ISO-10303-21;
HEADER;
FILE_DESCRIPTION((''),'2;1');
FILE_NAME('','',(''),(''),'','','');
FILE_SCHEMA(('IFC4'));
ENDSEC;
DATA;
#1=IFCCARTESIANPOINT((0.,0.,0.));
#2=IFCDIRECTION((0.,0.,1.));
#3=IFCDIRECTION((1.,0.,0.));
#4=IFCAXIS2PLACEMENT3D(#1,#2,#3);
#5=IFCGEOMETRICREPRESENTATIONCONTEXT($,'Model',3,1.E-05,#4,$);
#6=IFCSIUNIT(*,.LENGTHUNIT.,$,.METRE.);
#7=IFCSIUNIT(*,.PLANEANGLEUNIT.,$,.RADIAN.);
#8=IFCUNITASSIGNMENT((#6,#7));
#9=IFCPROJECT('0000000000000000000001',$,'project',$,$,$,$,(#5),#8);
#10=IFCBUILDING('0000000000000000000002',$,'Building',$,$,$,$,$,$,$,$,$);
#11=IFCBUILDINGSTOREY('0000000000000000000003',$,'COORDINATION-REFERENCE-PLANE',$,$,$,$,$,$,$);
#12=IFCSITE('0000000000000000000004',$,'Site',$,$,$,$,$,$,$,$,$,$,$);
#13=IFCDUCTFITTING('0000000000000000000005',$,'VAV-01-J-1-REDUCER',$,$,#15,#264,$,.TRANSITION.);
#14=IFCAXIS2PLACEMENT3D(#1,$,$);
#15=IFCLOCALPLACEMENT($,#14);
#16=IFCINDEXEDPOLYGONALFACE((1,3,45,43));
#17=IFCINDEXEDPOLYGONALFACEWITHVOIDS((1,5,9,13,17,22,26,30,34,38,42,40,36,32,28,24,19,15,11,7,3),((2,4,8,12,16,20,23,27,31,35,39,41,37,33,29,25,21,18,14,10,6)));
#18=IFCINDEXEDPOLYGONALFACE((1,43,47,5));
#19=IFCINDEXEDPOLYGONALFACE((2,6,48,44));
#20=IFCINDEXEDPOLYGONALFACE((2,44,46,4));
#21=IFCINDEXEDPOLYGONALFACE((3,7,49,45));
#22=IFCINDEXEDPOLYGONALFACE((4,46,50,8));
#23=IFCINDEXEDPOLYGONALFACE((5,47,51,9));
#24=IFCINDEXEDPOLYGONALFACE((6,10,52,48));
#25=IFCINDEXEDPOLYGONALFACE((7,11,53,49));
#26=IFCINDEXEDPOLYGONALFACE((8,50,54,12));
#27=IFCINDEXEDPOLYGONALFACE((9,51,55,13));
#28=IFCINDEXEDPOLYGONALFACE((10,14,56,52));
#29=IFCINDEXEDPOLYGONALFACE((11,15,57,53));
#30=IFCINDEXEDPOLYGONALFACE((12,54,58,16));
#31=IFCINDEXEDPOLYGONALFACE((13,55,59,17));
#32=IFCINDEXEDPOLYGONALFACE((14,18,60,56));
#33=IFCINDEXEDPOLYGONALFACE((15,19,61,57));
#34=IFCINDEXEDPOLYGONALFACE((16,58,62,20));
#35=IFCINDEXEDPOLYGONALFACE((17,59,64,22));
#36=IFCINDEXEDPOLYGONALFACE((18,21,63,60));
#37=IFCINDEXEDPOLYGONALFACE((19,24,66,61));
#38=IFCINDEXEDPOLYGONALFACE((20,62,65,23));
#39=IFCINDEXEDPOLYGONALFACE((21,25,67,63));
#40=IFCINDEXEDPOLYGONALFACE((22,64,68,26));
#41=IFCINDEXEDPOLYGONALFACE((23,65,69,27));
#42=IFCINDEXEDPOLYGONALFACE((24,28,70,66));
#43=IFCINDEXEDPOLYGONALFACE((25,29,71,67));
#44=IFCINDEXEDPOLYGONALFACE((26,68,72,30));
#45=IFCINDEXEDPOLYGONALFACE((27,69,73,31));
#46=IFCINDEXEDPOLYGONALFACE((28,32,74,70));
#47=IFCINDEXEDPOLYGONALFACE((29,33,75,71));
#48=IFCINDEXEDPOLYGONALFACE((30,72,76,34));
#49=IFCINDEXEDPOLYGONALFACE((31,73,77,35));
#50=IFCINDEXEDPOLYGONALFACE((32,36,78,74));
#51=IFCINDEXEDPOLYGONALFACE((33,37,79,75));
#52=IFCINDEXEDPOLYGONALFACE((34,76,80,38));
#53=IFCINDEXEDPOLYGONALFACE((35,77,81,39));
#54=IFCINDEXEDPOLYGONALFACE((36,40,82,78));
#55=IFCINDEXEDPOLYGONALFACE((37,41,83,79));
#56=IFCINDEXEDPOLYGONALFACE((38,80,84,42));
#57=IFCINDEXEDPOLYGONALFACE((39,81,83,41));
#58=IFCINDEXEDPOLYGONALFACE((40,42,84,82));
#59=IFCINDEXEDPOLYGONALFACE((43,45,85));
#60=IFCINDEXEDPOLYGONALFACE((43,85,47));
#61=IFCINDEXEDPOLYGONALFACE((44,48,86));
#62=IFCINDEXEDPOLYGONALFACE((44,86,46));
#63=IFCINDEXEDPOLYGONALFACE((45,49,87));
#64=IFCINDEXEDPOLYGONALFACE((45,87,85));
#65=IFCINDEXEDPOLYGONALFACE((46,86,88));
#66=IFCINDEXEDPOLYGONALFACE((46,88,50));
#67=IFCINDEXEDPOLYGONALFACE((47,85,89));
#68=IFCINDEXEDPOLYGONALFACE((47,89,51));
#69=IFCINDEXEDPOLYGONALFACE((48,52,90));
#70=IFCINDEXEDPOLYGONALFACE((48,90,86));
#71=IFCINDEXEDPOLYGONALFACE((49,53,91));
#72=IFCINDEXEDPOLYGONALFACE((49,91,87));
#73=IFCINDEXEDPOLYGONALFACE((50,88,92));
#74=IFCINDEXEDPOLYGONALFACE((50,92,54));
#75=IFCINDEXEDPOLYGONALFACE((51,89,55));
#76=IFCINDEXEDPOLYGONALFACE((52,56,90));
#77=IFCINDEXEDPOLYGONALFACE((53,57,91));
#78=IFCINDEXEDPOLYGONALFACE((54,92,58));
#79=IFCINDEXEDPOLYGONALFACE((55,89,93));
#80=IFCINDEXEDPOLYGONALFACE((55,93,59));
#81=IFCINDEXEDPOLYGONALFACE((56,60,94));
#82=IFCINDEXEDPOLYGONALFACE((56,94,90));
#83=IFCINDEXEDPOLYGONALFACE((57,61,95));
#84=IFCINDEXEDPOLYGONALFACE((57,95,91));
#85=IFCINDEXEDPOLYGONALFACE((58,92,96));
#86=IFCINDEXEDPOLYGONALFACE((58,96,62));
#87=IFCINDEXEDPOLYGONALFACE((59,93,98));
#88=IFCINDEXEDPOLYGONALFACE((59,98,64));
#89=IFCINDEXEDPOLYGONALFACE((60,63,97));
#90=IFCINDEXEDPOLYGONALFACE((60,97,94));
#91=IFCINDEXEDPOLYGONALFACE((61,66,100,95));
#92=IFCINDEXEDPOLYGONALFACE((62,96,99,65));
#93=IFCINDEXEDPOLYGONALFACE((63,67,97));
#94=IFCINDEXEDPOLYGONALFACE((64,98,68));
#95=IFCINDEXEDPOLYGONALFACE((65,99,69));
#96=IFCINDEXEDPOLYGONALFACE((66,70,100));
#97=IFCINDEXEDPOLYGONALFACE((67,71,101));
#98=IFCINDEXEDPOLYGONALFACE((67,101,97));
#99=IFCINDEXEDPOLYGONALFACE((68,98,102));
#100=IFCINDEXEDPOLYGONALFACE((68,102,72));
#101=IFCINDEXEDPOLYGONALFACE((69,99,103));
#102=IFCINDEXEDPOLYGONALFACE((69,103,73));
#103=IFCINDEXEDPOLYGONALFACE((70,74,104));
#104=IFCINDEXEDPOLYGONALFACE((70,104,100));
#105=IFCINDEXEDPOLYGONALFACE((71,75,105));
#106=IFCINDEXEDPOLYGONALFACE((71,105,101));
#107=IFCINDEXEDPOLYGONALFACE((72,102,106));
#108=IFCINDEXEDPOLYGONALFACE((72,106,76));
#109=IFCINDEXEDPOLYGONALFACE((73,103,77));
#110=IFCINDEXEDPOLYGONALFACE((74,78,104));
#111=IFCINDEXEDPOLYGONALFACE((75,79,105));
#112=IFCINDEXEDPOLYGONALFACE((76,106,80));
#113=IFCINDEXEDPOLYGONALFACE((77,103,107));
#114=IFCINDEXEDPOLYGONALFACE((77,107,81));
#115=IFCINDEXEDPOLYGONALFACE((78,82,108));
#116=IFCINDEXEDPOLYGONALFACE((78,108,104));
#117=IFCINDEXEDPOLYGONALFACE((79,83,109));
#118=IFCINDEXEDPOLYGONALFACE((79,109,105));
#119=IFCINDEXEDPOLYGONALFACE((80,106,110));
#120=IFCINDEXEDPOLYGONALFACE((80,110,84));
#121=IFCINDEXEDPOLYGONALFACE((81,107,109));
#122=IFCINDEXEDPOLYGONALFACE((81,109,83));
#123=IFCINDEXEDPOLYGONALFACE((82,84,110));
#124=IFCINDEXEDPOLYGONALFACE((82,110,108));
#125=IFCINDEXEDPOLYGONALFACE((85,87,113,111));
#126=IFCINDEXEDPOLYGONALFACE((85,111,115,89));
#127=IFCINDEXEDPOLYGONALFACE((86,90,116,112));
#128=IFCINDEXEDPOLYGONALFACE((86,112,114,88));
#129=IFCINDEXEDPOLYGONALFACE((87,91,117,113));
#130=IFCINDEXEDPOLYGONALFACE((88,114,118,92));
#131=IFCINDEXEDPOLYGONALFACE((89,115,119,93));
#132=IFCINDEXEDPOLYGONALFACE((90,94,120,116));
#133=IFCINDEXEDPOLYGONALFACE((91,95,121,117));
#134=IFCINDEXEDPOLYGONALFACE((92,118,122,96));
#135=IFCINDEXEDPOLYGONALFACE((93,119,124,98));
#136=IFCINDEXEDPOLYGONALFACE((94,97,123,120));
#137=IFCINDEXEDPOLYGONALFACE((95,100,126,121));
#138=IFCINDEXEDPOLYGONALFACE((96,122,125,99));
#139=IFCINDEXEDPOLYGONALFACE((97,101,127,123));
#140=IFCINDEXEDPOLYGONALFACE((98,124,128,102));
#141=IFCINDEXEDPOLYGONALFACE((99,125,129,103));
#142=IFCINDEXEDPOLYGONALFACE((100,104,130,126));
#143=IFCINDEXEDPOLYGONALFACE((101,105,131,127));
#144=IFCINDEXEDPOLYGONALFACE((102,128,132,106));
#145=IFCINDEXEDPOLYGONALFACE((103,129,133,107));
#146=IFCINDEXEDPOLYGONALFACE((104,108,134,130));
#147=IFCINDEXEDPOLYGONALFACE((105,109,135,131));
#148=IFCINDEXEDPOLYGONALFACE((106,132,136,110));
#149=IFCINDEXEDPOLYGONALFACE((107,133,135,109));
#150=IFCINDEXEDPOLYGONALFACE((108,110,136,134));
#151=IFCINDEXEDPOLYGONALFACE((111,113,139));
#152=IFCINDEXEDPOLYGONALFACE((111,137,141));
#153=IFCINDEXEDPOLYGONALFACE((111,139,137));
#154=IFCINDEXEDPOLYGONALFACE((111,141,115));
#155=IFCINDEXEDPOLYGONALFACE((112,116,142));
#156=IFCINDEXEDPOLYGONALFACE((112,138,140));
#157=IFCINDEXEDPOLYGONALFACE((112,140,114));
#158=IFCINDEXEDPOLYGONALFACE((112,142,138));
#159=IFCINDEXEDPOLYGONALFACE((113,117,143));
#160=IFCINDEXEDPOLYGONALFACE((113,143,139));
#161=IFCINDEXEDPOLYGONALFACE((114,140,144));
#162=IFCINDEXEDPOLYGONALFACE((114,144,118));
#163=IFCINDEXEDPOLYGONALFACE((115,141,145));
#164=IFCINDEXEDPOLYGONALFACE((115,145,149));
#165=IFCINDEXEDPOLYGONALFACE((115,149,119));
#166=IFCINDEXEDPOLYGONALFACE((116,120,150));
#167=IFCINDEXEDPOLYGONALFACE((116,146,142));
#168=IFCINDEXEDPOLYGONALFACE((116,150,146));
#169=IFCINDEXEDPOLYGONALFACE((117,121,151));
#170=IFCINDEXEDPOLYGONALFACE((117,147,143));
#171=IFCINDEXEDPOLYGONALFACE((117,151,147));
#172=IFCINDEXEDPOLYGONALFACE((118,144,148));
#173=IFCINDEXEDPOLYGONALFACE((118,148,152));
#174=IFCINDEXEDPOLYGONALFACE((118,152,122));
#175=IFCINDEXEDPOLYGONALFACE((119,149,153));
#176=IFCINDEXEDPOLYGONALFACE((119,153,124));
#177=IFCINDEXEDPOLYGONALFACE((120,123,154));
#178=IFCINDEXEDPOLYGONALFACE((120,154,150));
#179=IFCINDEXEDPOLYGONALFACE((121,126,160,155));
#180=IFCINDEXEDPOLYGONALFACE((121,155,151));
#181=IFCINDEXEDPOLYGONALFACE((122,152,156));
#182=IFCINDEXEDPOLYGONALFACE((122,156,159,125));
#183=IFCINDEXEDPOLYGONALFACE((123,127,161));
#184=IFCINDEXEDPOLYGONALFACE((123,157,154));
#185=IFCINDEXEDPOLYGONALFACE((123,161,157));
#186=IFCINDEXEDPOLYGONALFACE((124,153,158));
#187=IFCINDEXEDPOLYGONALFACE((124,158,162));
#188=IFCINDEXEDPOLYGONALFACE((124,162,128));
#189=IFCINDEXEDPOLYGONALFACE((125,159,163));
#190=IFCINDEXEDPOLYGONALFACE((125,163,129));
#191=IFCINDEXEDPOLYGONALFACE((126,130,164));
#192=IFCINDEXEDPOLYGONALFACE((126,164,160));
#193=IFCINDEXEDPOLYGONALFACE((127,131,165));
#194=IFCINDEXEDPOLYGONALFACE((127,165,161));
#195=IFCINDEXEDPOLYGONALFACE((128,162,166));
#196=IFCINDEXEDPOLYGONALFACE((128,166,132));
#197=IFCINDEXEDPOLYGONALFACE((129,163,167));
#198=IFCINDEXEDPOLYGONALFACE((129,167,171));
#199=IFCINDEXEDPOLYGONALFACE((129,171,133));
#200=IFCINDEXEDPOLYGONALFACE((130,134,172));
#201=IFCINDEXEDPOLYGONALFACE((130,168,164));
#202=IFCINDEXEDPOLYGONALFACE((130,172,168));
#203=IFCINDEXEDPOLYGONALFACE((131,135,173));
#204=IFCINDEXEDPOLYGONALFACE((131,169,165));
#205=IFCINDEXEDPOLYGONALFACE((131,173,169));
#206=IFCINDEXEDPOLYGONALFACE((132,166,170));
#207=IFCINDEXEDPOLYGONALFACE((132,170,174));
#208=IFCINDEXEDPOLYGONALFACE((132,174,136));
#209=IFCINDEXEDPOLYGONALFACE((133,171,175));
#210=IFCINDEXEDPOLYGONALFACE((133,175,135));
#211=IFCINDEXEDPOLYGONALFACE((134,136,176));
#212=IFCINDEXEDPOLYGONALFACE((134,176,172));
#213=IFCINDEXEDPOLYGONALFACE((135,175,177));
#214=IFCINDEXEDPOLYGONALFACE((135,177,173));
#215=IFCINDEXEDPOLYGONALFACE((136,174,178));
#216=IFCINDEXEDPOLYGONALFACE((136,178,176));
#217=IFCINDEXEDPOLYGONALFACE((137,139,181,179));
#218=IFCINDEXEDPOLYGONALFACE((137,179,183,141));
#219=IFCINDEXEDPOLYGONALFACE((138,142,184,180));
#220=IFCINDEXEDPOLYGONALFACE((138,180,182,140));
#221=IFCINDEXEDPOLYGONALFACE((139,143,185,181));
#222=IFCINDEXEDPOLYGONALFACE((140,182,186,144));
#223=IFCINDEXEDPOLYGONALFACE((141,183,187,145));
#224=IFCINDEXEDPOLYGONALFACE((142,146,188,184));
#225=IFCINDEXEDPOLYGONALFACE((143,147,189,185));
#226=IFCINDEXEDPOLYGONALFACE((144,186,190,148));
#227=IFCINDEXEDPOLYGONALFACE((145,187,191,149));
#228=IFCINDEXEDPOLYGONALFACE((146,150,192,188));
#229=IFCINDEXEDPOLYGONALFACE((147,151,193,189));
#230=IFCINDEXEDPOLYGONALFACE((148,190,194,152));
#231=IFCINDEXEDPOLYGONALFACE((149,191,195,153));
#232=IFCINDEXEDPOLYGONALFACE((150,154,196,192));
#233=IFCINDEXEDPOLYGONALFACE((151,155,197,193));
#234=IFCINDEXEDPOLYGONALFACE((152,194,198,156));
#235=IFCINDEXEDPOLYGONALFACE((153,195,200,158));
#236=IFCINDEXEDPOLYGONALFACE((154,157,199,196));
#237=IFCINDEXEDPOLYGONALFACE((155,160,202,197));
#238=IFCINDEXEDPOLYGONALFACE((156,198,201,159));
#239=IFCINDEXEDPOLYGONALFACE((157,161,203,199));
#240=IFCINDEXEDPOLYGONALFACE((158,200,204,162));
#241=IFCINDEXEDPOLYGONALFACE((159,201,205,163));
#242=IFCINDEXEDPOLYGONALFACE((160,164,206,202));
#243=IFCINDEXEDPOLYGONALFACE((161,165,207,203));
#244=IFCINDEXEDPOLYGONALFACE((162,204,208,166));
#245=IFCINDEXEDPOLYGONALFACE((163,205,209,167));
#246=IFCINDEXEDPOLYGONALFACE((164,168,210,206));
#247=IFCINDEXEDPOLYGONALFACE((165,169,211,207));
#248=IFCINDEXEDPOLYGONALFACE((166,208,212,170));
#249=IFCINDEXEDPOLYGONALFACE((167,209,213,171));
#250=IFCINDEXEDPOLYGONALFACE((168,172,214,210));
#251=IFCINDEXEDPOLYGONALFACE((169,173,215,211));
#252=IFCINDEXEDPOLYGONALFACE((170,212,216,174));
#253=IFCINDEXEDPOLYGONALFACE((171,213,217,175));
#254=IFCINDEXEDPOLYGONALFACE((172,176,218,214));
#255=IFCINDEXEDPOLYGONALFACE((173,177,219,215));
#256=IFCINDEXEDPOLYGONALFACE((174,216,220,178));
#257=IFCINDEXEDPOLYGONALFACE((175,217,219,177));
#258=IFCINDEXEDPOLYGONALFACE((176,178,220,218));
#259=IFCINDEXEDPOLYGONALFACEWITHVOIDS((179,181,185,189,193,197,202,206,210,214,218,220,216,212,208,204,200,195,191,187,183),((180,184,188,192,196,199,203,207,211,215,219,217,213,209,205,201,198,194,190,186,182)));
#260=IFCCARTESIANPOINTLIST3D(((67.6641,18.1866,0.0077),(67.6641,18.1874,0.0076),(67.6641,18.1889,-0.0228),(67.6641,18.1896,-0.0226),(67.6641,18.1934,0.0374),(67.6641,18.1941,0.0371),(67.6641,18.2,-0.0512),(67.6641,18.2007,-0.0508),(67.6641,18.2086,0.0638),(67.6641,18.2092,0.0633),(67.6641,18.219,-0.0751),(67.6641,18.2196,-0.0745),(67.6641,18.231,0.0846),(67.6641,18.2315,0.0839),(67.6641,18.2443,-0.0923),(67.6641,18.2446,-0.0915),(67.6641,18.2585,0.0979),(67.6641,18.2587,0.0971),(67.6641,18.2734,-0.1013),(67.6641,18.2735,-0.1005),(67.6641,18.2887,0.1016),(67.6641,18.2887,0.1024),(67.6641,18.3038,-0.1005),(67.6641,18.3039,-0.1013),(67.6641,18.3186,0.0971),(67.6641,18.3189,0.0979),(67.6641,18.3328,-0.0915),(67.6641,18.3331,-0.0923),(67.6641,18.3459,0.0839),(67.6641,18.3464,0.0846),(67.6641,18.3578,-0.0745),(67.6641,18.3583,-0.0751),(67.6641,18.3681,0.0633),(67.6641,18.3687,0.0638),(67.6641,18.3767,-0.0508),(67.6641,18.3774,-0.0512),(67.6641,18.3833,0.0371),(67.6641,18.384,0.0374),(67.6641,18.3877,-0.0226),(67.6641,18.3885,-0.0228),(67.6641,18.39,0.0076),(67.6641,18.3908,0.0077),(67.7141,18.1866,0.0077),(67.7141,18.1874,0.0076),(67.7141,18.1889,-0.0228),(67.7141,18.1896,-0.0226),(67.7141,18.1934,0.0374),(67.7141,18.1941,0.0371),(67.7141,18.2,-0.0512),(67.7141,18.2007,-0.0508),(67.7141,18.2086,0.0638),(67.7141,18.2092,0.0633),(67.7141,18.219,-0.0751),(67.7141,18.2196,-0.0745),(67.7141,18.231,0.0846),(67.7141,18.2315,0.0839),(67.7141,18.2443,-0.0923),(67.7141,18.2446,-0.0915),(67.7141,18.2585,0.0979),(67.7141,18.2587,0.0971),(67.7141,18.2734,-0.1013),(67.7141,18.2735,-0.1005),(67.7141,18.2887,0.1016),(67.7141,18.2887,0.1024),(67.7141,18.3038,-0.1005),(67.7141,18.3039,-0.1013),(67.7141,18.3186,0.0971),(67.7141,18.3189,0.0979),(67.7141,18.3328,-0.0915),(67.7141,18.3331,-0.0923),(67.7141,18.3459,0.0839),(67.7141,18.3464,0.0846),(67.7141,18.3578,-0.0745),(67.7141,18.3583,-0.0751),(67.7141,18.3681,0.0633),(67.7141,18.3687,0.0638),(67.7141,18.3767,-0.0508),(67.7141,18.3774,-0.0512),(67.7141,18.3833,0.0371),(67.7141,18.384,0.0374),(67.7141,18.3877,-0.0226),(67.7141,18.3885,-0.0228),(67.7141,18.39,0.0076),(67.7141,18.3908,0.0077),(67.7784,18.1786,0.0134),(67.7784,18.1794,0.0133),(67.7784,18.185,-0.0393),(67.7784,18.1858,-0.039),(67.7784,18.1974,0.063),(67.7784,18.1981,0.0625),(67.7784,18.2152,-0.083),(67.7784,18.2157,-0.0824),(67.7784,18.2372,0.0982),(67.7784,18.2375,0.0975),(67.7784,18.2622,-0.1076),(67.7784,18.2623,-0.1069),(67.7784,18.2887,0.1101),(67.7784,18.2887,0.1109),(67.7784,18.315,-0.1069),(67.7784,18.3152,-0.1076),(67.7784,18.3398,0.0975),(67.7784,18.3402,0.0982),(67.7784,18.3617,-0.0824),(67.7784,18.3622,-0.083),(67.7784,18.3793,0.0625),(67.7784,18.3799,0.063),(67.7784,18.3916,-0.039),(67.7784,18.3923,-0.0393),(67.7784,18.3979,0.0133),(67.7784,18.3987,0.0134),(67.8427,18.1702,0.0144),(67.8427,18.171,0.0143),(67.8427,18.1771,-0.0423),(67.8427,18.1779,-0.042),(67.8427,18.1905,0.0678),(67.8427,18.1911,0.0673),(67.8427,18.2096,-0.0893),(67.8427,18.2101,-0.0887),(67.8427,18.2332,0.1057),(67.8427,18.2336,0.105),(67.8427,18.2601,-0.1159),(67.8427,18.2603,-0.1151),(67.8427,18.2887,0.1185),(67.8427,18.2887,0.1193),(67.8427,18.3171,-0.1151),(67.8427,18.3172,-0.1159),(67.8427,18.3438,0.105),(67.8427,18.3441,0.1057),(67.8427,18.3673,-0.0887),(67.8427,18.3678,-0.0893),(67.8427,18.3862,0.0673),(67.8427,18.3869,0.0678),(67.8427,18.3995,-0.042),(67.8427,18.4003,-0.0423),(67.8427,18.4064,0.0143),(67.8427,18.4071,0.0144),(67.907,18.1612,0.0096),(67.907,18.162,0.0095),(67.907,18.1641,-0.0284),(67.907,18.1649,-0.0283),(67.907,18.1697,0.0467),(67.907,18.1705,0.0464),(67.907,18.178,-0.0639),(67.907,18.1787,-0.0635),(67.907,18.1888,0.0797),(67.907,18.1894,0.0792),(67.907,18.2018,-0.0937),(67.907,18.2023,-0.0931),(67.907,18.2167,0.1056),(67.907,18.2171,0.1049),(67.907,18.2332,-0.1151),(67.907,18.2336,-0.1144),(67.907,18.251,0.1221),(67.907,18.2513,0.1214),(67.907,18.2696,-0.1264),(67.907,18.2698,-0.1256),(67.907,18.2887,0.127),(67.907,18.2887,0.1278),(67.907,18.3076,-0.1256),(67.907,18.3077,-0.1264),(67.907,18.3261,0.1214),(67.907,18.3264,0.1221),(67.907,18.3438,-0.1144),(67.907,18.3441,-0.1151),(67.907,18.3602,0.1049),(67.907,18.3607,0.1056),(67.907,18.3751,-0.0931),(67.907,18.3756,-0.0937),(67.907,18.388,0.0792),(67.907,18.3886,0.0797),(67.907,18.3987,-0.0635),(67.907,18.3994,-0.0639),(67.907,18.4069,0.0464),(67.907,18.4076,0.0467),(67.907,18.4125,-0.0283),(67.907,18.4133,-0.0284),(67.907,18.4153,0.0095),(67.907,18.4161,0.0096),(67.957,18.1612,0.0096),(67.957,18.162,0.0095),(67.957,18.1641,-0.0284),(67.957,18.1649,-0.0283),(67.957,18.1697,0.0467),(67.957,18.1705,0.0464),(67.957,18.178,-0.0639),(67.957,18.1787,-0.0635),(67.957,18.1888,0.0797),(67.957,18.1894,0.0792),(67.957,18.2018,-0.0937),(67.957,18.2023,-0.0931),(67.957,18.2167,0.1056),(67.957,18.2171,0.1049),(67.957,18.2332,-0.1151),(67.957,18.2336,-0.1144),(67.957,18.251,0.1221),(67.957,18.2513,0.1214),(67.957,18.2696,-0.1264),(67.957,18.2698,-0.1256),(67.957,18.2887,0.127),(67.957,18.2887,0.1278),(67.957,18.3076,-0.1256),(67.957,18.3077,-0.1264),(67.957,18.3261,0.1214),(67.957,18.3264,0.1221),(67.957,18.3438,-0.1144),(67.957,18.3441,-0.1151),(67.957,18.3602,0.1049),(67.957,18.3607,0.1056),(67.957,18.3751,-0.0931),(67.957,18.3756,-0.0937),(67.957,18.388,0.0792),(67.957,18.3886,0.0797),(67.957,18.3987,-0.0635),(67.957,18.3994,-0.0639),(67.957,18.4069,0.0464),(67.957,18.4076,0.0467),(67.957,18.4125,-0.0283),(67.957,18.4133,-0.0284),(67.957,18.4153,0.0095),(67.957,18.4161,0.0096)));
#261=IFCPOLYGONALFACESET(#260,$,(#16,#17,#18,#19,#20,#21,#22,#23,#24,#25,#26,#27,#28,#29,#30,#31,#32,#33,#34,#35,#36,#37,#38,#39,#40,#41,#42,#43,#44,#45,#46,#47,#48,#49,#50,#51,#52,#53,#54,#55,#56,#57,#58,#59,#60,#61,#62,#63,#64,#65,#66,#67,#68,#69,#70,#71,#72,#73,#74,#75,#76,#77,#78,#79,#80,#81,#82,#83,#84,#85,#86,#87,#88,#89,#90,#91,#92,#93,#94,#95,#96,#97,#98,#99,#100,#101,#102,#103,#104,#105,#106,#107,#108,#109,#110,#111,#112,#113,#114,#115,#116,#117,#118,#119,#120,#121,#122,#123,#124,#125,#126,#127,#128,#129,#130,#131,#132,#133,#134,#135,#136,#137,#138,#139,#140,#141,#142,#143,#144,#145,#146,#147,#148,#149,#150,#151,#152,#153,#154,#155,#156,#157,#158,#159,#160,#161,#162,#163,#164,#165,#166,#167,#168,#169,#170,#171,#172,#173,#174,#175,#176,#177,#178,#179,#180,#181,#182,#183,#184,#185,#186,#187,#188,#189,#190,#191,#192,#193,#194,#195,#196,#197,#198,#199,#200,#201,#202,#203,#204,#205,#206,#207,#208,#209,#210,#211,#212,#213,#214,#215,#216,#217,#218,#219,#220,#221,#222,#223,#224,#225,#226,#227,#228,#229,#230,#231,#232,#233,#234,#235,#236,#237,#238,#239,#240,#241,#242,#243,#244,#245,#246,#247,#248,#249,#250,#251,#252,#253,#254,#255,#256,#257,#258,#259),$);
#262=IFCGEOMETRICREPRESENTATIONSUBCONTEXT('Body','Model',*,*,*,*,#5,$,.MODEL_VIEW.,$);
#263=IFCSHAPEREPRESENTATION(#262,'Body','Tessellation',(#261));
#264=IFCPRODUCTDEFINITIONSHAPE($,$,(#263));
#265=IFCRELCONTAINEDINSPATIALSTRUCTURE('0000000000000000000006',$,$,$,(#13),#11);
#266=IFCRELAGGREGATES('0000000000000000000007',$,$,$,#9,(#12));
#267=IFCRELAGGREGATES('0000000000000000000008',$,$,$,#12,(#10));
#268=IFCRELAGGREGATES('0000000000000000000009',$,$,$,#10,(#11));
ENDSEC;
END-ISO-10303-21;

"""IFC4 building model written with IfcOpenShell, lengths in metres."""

from ifc_helpers import new_model, entity, si_unit, frame, origin_with_axes, place, context, subcontext, project, spatial, element, save


model = new_model("IFC4")

# Units and contexts
model_context = context("Model", 3, precision=1e-05, world=origin_with_axes())
body_context_1 = subcontext(model_context, "Body", "Model", "MODEL_VIEW")
ifc_project = project(units=[si_unit("LENGTHUNIT", "METRE"), si_unit("PLANEANGLEUNIT", "RADIAN")], contexts=[model_context])

# Site, building, storey
site = spatial("IfcSite", under=ifc_project, Name="Site")
building = spatial("IfcBuilding", under=site, Name="Building")
storey = spatial("IfcBuildingStorey", under=building, Name="COORDINATION-REFERENCE-PLANE")

# Duct fitting
duct_fitting_1_placement = place(None, frame((67.957, 18.2887, 0.0), z_axis=(0.0, -1.0, 0.0), x_axis=(0.0, 0.0, 1.0)))
element("IfcDuctFitting", 1, at=duct_fitting_1_placement, inside=storey, Name="VAV-01-J-1-REDUCER", PredefinedType="TRANSITION", context=body_context_1, shape_type="SweptSolid", body=[
    entity("IfcRevolvedAreaSolid", entity("IfcArbitraryClosedProfileDef", "AREA", None, entity("IfcPolyline", [entity("IfcCartesianPoint", [0.1278, 0.0]), entity("IfcCartesianPoint", [0.1278, 0.05]), entity("IfcCartesianPoint", [0.1024, 0.2429]), entity("IfcCartesianPoint", [0.1024, 0.2929]), entity("IfcCartesianPoint", [0.1016, 0.2929]), entity("IfcCartesianPoint", [0.1016, 0.2429]), entity("IfcCartesianPoint", [0.127, 0.05]), entity("IfcCartesianPoint", [0.127, 0.0]), entity("IfcCartesianPoint", [0.1278, 0.0])])), entity("IfcAxis2Placement3D", entity("IfcCartesianPoint", [0.0, 0.0, 0.0])), entity("IfcAxis1Placement", entity("IfcCartesianPoint", [0.0, 0.0, 0.0]), entity("IfcDirection", [0.0, 1.0, 0.0])), 6.283185),
])

save(model, "model.ifc")
